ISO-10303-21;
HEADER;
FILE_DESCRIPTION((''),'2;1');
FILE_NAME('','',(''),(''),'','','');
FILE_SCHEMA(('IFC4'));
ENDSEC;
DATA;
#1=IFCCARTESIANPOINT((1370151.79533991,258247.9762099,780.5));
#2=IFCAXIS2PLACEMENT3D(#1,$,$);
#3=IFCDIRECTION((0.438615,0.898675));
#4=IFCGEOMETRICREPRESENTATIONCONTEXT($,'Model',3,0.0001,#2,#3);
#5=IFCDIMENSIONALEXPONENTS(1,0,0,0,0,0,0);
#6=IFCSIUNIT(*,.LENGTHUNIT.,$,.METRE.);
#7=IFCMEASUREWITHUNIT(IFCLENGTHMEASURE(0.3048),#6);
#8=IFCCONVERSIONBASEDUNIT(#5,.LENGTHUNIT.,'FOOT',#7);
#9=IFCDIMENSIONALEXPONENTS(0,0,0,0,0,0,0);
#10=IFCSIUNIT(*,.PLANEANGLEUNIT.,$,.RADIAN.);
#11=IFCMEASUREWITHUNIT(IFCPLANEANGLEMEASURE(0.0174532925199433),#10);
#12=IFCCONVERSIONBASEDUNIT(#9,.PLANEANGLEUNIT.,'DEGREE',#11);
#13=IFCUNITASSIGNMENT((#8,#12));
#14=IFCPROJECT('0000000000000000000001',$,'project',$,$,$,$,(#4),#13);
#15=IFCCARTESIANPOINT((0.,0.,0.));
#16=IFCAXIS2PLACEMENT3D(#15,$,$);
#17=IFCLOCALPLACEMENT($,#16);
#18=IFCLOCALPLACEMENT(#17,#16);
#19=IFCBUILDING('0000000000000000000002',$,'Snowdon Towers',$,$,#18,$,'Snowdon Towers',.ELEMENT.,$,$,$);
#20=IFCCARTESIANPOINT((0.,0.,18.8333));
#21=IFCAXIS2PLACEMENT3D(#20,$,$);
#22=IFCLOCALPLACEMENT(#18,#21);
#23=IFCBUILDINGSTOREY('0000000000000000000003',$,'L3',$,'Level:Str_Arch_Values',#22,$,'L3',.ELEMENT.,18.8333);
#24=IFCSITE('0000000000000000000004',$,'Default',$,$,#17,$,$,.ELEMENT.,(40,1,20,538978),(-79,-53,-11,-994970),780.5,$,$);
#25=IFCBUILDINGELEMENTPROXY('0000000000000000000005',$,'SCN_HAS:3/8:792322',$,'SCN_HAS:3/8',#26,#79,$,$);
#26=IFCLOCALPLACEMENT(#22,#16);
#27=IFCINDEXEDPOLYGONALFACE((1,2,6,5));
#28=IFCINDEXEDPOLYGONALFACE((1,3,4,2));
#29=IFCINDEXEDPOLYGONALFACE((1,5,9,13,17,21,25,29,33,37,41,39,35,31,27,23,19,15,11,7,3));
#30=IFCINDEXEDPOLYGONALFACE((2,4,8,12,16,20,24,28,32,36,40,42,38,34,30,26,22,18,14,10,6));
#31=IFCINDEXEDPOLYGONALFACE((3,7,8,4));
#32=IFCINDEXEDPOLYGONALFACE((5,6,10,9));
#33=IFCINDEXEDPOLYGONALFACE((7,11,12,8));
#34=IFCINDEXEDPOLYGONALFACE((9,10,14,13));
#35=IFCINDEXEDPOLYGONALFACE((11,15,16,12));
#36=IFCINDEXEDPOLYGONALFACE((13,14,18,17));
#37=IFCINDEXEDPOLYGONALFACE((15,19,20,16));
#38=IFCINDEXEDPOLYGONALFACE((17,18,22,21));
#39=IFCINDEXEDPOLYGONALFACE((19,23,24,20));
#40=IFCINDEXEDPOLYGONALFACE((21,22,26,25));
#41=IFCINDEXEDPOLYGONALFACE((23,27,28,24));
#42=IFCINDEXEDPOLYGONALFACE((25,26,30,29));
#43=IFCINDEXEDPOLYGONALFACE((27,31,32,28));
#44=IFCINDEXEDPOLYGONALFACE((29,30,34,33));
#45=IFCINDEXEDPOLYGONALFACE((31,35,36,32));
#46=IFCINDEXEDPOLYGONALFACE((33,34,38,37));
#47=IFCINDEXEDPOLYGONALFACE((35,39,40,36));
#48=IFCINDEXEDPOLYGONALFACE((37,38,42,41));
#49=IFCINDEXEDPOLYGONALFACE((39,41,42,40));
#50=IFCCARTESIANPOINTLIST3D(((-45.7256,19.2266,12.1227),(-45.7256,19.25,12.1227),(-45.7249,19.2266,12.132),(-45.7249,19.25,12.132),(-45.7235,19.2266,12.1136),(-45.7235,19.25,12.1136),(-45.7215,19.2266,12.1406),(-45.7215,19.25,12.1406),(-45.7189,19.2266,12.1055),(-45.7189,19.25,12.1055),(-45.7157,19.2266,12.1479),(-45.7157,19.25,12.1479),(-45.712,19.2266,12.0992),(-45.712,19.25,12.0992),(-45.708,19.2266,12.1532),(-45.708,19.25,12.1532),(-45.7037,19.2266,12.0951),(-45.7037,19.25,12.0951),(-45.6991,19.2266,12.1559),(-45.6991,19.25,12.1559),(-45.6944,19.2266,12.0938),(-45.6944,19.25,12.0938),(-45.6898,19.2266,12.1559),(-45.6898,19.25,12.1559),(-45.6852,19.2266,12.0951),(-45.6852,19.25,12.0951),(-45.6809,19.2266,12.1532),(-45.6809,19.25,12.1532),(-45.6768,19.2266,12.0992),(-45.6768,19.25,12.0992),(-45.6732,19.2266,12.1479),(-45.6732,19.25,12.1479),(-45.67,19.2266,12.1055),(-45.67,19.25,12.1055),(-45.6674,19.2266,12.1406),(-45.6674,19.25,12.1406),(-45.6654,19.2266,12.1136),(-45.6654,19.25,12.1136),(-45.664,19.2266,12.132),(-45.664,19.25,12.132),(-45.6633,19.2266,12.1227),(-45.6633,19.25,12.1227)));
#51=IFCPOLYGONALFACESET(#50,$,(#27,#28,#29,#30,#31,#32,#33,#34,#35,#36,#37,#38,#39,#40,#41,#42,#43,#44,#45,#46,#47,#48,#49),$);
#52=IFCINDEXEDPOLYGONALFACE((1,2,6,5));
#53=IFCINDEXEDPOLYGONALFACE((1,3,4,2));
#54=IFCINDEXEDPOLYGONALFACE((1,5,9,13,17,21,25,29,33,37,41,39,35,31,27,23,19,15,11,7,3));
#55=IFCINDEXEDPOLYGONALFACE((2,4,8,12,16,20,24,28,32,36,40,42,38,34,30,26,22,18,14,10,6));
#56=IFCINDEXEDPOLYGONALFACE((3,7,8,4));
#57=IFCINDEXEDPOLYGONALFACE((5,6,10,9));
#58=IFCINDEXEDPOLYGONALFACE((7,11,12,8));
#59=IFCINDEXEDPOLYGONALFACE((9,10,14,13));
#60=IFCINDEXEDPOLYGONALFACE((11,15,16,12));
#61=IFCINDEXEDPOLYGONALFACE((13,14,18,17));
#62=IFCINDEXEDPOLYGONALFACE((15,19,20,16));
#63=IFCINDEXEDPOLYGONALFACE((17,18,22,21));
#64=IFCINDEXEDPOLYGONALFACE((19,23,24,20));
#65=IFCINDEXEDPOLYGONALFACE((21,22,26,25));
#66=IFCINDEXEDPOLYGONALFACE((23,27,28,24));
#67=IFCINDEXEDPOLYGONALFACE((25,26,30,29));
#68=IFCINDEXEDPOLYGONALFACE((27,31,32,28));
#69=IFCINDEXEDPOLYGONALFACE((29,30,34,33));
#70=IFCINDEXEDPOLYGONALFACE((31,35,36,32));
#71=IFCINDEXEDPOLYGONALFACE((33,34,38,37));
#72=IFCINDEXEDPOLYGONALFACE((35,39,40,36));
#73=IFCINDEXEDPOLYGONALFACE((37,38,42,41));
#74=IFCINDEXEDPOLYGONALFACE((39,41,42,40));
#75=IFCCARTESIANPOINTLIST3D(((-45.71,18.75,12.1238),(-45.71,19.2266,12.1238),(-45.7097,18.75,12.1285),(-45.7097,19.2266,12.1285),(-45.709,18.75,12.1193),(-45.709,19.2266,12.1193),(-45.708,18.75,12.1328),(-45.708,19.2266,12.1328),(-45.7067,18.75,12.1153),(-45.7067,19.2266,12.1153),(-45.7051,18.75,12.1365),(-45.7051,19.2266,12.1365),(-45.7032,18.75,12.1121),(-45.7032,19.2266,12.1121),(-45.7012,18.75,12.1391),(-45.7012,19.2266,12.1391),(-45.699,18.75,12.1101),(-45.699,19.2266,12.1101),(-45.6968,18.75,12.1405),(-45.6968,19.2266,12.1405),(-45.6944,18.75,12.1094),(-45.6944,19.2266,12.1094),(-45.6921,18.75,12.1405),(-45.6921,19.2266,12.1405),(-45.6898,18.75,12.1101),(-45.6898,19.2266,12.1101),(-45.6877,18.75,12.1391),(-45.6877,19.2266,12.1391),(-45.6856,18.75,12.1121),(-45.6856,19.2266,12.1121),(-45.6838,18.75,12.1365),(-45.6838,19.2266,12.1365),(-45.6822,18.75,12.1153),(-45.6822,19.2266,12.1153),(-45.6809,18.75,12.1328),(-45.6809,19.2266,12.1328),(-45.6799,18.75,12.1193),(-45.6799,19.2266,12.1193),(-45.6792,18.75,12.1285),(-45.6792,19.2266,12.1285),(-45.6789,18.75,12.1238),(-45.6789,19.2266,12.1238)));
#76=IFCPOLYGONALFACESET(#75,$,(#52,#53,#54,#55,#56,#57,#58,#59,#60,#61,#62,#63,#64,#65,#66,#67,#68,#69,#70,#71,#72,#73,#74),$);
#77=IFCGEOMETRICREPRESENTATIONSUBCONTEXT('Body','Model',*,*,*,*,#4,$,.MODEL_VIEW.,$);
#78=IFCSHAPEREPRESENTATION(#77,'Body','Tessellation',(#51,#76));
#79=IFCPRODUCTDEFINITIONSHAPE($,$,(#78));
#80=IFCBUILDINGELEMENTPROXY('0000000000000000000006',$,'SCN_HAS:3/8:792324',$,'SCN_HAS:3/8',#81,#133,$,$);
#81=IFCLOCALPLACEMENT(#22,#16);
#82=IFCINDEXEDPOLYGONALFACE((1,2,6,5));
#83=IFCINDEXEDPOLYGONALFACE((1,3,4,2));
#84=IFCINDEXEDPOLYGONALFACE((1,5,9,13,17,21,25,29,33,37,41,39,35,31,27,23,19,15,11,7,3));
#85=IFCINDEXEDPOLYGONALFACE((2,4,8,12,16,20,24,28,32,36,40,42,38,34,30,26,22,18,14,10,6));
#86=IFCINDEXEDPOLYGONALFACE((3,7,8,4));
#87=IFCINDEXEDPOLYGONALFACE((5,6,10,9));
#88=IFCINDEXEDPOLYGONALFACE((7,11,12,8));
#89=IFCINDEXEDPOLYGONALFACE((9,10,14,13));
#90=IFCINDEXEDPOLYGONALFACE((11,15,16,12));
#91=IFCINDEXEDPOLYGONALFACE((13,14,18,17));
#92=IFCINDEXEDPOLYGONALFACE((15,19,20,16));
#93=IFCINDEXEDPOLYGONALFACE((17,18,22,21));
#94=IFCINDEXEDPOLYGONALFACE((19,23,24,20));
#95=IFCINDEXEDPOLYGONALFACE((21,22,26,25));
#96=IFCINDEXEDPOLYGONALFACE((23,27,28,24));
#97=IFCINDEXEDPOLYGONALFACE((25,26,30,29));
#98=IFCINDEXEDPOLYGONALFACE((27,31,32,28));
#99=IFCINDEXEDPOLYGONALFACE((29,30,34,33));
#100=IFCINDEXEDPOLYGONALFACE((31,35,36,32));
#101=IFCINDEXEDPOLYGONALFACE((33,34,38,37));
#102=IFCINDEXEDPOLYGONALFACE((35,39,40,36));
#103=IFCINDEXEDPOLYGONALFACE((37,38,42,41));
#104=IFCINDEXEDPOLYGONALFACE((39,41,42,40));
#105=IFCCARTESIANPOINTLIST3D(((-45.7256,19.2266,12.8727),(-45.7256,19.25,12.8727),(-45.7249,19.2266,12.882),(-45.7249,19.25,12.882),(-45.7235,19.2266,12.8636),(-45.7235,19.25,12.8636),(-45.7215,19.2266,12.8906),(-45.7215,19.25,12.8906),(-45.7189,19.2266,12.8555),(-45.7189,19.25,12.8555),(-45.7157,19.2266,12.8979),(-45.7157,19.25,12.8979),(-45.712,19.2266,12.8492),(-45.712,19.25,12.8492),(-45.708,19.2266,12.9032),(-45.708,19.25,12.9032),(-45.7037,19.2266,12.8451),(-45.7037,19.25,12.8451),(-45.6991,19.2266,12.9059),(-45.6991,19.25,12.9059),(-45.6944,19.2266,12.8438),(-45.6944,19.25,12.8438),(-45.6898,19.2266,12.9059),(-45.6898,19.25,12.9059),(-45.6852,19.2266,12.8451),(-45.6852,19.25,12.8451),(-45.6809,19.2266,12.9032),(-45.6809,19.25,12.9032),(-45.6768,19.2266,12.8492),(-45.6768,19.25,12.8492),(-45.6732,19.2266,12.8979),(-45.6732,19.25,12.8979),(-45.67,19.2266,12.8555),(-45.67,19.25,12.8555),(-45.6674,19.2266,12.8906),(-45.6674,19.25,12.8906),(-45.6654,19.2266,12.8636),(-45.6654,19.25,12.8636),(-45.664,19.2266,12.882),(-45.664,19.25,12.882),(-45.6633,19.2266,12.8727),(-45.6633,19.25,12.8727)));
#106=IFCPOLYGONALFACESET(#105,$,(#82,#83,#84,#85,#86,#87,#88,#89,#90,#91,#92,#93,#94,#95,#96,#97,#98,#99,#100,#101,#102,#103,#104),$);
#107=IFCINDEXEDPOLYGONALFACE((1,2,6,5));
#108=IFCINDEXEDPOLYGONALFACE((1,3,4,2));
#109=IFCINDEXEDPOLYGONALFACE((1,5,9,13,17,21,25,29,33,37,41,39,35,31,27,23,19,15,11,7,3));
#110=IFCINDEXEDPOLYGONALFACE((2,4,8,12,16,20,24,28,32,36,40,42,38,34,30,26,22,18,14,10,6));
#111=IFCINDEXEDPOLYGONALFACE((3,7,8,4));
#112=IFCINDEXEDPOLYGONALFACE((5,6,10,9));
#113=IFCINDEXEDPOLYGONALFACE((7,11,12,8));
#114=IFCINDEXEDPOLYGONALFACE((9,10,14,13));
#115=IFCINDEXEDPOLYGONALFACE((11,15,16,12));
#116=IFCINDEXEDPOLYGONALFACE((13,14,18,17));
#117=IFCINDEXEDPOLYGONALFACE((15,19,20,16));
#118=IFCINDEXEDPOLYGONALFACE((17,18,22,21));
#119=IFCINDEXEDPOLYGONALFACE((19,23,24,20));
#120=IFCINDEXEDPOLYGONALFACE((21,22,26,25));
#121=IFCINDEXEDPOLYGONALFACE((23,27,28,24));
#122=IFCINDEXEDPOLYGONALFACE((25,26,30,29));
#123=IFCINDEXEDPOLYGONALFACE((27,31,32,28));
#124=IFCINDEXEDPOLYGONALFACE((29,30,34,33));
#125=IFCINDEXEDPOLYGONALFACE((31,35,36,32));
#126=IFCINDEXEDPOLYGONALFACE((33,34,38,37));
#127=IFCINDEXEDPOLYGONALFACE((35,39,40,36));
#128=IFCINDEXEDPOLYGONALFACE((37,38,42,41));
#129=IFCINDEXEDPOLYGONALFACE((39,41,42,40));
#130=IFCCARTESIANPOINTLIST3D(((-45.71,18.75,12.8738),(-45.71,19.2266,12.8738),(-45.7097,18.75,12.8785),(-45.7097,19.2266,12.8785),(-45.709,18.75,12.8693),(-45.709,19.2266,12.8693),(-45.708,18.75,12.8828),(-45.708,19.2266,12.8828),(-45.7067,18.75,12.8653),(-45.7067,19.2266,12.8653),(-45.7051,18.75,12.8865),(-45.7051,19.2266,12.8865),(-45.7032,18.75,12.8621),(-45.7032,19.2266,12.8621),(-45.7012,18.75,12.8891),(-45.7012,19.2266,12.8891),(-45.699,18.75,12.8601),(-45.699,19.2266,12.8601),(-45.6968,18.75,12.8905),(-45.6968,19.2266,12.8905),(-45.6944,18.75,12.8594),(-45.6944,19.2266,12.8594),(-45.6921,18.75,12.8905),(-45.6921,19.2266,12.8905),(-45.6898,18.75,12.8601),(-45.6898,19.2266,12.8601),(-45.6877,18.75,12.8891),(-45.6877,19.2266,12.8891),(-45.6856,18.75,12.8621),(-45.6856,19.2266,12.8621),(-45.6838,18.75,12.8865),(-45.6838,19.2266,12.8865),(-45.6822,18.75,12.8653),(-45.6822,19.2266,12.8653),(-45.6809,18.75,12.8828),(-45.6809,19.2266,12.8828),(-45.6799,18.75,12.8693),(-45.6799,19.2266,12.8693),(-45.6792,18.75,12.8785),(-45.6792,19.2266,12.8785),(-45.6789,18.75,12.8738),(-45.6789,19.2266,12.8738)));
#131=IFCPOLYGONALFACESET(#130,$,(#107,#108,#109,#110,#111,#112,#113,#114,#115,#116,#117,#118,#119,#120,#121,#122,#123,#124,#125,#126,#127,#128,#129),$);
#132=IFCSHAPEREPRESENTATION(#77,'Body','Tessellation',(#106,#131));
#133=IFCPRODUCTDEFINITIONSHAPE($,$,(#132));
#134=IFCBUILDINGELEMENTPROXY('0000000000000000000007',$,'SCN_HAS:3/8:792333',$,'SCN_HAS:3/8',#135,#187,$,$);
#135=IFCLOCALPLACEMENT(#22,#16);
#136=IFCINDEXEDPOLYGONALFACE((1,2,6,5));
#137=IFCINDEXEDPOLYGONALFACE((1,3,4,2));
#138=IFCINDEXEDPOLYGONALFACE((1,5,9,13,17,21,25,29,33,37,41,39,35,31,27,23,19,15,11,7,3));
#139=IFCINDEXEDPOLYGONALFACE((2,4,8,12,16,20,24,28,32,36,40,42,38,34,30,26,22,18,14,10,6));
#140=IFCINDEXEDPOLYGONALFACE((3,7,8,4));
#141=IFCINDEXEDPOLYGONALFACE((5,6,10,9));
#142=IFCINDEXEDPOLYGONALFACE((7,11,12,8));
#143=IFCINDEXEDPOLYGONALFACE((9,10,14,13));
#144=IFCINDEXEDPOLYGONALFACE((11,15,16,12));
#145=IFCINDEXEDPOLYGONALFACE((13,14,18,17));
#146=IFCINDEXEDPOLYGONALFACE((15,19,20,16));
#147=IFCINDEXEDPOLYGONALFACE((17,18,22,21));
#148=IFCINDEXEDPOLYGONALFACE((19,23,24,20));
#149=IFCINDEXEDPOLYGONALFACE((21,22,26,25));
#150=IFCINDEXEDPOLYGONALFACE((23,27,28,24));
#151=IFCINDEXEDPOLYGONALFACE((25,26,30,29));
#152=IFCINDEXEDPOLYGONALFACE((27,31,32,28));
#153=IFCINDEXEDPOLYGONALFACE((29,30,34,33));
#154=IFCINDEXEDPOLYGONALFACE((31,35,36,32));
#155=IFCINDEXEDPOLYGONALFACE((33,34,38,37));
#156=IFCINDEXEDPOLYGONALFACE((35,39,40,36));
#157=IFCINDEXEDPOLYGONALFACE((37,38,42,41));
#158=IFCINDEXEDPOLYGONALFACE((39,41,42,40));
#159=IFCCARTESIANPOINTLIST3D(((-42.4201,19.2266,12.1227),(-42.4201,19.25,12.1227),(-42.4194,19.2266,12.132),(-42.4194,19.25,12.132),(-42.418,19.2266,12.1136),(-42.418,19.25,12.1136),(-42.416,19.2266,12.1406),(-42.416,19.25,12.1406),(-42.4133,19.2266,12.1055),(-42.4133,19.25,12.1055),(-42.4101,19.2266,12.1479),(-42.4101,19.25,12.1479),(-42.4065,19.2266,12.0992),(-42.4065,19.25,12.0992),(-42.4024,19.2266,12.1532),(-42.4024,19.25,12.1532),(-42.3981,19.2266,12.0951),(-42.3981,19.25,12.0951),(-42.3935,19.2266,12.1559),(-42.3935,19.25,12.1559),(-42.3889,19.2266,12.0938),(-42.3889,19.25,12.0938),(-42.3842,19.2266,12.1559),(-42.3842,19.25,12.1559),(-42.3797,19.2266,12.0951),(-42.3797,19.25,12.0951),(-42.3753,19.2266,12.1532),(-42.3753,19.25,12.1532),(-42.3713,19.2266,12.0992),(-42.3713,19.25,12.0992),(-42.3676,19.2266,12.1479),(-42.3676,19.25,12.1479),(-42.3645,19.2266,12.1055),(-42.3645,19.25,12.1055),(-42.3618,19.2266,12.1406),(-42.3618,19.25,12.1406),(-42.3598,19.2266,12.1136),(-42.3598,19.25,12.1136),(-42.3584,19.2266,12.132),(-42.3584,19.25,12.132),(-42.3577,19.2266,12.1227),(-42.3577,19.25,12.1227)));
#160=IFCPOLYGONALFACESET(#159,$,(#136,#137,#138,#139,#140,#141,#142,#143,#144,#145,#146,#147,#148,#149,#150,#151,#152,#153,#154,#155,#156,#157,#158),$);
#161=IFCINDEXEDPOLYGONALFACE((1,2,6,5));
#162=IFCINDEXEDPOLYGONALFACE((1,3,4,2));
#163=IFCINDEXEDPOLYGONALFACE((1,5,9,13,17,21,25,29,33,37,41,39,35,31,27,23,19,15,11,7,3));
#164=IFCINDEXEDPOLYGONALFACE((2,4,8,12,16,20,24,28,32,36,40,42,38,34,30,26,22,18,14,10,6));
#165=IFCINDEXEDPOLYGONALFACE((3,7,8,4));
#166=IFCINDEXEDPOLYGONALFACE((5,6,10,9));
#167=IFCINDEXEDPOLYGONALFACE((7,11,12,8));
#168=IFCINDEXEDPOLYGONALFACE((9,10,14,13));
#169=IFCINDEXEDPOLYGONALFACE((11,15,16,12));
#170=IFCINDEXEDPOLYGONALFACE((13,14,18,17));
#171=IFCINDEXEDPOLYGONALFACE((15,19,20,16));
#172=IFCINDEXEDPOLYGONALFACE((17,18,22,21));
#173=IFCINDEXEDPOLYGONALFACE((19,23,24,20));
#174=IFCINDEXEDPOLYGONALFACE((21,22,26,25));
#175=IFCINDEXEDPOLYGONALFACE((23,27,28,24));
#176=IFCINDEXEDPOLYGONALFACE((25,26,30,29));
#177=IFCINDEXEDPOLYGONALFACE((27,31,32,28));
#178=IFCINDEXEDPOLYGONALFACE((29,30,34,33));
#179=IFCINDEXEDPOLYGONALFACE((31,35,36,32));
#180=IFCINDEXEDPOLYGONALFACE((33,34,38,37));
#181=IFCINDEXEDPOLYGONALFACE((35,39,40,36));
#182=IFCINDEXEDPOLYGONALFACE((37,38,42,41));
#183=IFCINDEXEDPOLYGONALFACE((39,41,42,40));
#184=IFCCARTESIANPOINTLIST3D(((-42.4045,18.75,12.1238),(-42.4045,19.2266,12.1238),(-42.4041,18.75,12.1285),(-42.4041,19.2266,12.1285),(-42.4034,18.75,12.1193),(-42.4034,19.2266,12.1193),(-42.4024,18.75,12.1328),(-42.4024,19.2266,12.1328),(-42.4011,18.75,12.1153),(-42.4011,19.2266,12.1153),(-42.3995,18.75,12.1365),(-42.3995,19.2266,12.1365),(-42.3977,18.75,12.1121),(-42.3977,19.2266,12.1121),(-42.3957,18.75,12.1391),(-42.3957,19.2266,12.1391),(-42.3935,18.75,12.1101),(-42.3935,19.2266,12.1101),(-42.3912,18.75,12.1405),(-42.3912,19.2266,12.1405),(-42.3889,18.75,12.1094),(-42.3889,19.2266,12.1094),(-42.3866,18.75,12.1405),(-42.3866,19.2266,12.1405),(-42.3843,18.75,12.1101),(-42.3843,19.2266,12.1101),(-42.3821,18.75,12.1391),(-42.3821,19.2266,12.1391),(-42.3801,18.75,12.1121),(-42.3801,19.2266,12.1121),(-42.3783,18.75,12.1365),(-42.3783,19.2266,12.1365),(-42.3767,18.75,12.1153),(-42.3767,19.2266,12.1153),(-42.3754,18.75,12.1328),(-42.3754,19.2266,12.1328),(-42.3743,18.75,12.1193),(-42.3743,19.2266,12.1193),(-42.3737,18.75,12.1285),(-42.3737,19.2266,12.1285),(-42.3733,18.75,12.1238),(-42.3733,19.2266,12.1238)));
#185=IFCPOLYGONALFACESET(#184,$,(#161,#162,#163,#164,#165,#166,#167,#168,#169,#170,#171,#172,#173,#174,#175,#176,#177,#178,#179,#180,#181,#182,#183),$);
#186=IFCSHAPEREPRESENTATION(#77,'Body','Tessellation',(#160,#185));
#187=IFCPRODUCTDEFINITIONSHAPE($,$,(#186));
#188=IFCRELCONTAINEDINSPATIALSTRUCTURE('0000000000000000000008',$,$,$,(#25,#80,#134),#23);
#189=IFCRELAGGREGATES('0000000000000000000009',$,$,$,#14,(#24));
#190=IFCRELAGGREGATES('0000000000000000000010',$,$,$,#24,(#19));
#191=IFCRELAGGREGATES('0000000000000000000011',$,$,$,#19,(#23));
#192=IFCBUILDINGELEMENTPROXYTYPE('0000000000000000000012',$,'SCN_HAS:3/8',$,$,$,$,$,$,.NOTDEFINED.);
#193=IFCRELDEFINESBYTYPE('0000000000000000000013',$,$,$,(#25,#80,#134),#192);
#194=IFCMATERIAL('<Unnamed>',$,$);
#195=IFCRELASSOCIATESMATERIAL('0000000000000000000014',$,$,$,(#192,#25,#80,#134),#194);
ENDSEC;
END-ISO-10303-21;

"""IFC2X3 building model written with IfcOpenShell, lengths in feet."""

from ifc_helpers import new_model, entity, si_unit, converted_unit, direction, frame, frame_2d, origin, place, context, subcontext, project, spatial, circle, extrude, source, transform, mapped, material, type_object, type_shapes, element, save


model = new_model("IFC2X3")

# Units and contexts
model_context = context("Model", 3, precision=0.0001, world=frame((1370151.79533991, 258247.9762099, 780.5)), true_north=direction((0.438615, 0.898675)))
body_context = subcontext(model_context, "Body", "Model", "MODEL_VIEW")
ifc_project = project(units=[converted_unit("LENGTHUNIT", "FOOT", entity("IfcLengthMeasure", 0.3048), si_unit("LENGTHUNIT", "METRE"), dimensions=[1, 0, 0, 0, 0, 0, 0]), converted_unit("PLANEANGLEUNIT", "DEGREE", entity("IfcPlaneAngleMeasure", 0.0174532925199433), si_unit("PLANEANGLEUNIT", "RADIAN"), dimensions=[0, 0, 0, 0, 0, 0, 0])], contexts=[model_context])

# Site, building, storey
site_placement = place(None, origin())
site = spatial("IfcSite", under=ifc_project, at=site_placement, Name="Default", CompositionType="ELEMENT", RefLatitude=(40, 1, 20, 538978), RefLongitude=(-79, -53, -11, -994970), RefElevation=780.5)
building_placement = place(site_placement, origin())
building = spatial("IfcBuilding", under=site, at=building_placement, Name="Snowdon Towers", LongName="Snowdon Towers", CompositionType="ELEMENT")
storey_placement = place(building_placement, frame((0.0, 0.0, 18.8333)))
storey = spatial("IfcBuildingStorey", under=building, at=storey_placement, Name="L3", ObjectType="Level:Str_Arch_Values", LongName="L3", CompositionType="ELEMENT", Elevation=18.8333)

# Building element proxies
ifc_material_1 = material(Name="<Unnamed>")
building_element_proxy_type_1 = type_object("IfcBuildingElementProxyType", Name="SCN_HAS:3/8", PredefinedType="NOTDEFINED", material=ifc_material_1)
shared_shape_1 = source(origin(), body_context, "Body", "SweptSolid", [
    extrude(circle(Radius=0.0312, at=frame_2d((0.0, 0.0), x_axis=(1.0, 0.0))), frame((0.0, 0.0, -0.5), z_axis=(0.0, 0.0, 1.0), x_axis=(0.0, -1.0, 0.0)), (0.0, 0.0, 1.0), 0.0234),
    extrude(circle(Radius=0.0156, at=frame_2d((0.0, 0.0), x_axis=(1.0, 0.0))), frame((0.0, 0.0, -0.4766), z_axis=(0.0, 0.0, 1.0), x_axis=(0.0, -1.0, 0.0)), (0.0, 0.0, 1.0), 0.4766),
])
type_shapes(building_element_proxy_type_1, [shared_shape_1])
for number, where, z_axis, x_axis, name in (
    (1, (-45.6944, 18.75, 12.125), (0.0, -1.0, 0.0), (1.0, 0.0, 0.0), "SCN_HAS:3/8:792322"),
    (2, (-45.6944, 18.75, 12.875), (0.0, -1.0, 0.0), (1.0, 0.0, 0.0), "SCN_HAS:3/8:792324"),
    (3, (-42.3889, 18.75, 12.125), (0.0, -1.0, 0.0), (1.0, 0.0, 0.0), "SCN_HAS:3/8:792333"),
):
    element("IfcBuildingElementProxy", number, at=place(storey_placement, frame(where, z_axis=z_axis, x_axis=x_axis)), inside=storey, type_object=building_element_proxy_type_1, material=ifc_material_1, Name=name, ObjectType="SCN_HAS:3/8", context=body_context, shape_type="MappedRepresentation", body=[
        mapped(shared_shape_1, transform((0.0, 0.0, 0.0), scale=1.0)),
    ])

save(model, "model.ifc")
